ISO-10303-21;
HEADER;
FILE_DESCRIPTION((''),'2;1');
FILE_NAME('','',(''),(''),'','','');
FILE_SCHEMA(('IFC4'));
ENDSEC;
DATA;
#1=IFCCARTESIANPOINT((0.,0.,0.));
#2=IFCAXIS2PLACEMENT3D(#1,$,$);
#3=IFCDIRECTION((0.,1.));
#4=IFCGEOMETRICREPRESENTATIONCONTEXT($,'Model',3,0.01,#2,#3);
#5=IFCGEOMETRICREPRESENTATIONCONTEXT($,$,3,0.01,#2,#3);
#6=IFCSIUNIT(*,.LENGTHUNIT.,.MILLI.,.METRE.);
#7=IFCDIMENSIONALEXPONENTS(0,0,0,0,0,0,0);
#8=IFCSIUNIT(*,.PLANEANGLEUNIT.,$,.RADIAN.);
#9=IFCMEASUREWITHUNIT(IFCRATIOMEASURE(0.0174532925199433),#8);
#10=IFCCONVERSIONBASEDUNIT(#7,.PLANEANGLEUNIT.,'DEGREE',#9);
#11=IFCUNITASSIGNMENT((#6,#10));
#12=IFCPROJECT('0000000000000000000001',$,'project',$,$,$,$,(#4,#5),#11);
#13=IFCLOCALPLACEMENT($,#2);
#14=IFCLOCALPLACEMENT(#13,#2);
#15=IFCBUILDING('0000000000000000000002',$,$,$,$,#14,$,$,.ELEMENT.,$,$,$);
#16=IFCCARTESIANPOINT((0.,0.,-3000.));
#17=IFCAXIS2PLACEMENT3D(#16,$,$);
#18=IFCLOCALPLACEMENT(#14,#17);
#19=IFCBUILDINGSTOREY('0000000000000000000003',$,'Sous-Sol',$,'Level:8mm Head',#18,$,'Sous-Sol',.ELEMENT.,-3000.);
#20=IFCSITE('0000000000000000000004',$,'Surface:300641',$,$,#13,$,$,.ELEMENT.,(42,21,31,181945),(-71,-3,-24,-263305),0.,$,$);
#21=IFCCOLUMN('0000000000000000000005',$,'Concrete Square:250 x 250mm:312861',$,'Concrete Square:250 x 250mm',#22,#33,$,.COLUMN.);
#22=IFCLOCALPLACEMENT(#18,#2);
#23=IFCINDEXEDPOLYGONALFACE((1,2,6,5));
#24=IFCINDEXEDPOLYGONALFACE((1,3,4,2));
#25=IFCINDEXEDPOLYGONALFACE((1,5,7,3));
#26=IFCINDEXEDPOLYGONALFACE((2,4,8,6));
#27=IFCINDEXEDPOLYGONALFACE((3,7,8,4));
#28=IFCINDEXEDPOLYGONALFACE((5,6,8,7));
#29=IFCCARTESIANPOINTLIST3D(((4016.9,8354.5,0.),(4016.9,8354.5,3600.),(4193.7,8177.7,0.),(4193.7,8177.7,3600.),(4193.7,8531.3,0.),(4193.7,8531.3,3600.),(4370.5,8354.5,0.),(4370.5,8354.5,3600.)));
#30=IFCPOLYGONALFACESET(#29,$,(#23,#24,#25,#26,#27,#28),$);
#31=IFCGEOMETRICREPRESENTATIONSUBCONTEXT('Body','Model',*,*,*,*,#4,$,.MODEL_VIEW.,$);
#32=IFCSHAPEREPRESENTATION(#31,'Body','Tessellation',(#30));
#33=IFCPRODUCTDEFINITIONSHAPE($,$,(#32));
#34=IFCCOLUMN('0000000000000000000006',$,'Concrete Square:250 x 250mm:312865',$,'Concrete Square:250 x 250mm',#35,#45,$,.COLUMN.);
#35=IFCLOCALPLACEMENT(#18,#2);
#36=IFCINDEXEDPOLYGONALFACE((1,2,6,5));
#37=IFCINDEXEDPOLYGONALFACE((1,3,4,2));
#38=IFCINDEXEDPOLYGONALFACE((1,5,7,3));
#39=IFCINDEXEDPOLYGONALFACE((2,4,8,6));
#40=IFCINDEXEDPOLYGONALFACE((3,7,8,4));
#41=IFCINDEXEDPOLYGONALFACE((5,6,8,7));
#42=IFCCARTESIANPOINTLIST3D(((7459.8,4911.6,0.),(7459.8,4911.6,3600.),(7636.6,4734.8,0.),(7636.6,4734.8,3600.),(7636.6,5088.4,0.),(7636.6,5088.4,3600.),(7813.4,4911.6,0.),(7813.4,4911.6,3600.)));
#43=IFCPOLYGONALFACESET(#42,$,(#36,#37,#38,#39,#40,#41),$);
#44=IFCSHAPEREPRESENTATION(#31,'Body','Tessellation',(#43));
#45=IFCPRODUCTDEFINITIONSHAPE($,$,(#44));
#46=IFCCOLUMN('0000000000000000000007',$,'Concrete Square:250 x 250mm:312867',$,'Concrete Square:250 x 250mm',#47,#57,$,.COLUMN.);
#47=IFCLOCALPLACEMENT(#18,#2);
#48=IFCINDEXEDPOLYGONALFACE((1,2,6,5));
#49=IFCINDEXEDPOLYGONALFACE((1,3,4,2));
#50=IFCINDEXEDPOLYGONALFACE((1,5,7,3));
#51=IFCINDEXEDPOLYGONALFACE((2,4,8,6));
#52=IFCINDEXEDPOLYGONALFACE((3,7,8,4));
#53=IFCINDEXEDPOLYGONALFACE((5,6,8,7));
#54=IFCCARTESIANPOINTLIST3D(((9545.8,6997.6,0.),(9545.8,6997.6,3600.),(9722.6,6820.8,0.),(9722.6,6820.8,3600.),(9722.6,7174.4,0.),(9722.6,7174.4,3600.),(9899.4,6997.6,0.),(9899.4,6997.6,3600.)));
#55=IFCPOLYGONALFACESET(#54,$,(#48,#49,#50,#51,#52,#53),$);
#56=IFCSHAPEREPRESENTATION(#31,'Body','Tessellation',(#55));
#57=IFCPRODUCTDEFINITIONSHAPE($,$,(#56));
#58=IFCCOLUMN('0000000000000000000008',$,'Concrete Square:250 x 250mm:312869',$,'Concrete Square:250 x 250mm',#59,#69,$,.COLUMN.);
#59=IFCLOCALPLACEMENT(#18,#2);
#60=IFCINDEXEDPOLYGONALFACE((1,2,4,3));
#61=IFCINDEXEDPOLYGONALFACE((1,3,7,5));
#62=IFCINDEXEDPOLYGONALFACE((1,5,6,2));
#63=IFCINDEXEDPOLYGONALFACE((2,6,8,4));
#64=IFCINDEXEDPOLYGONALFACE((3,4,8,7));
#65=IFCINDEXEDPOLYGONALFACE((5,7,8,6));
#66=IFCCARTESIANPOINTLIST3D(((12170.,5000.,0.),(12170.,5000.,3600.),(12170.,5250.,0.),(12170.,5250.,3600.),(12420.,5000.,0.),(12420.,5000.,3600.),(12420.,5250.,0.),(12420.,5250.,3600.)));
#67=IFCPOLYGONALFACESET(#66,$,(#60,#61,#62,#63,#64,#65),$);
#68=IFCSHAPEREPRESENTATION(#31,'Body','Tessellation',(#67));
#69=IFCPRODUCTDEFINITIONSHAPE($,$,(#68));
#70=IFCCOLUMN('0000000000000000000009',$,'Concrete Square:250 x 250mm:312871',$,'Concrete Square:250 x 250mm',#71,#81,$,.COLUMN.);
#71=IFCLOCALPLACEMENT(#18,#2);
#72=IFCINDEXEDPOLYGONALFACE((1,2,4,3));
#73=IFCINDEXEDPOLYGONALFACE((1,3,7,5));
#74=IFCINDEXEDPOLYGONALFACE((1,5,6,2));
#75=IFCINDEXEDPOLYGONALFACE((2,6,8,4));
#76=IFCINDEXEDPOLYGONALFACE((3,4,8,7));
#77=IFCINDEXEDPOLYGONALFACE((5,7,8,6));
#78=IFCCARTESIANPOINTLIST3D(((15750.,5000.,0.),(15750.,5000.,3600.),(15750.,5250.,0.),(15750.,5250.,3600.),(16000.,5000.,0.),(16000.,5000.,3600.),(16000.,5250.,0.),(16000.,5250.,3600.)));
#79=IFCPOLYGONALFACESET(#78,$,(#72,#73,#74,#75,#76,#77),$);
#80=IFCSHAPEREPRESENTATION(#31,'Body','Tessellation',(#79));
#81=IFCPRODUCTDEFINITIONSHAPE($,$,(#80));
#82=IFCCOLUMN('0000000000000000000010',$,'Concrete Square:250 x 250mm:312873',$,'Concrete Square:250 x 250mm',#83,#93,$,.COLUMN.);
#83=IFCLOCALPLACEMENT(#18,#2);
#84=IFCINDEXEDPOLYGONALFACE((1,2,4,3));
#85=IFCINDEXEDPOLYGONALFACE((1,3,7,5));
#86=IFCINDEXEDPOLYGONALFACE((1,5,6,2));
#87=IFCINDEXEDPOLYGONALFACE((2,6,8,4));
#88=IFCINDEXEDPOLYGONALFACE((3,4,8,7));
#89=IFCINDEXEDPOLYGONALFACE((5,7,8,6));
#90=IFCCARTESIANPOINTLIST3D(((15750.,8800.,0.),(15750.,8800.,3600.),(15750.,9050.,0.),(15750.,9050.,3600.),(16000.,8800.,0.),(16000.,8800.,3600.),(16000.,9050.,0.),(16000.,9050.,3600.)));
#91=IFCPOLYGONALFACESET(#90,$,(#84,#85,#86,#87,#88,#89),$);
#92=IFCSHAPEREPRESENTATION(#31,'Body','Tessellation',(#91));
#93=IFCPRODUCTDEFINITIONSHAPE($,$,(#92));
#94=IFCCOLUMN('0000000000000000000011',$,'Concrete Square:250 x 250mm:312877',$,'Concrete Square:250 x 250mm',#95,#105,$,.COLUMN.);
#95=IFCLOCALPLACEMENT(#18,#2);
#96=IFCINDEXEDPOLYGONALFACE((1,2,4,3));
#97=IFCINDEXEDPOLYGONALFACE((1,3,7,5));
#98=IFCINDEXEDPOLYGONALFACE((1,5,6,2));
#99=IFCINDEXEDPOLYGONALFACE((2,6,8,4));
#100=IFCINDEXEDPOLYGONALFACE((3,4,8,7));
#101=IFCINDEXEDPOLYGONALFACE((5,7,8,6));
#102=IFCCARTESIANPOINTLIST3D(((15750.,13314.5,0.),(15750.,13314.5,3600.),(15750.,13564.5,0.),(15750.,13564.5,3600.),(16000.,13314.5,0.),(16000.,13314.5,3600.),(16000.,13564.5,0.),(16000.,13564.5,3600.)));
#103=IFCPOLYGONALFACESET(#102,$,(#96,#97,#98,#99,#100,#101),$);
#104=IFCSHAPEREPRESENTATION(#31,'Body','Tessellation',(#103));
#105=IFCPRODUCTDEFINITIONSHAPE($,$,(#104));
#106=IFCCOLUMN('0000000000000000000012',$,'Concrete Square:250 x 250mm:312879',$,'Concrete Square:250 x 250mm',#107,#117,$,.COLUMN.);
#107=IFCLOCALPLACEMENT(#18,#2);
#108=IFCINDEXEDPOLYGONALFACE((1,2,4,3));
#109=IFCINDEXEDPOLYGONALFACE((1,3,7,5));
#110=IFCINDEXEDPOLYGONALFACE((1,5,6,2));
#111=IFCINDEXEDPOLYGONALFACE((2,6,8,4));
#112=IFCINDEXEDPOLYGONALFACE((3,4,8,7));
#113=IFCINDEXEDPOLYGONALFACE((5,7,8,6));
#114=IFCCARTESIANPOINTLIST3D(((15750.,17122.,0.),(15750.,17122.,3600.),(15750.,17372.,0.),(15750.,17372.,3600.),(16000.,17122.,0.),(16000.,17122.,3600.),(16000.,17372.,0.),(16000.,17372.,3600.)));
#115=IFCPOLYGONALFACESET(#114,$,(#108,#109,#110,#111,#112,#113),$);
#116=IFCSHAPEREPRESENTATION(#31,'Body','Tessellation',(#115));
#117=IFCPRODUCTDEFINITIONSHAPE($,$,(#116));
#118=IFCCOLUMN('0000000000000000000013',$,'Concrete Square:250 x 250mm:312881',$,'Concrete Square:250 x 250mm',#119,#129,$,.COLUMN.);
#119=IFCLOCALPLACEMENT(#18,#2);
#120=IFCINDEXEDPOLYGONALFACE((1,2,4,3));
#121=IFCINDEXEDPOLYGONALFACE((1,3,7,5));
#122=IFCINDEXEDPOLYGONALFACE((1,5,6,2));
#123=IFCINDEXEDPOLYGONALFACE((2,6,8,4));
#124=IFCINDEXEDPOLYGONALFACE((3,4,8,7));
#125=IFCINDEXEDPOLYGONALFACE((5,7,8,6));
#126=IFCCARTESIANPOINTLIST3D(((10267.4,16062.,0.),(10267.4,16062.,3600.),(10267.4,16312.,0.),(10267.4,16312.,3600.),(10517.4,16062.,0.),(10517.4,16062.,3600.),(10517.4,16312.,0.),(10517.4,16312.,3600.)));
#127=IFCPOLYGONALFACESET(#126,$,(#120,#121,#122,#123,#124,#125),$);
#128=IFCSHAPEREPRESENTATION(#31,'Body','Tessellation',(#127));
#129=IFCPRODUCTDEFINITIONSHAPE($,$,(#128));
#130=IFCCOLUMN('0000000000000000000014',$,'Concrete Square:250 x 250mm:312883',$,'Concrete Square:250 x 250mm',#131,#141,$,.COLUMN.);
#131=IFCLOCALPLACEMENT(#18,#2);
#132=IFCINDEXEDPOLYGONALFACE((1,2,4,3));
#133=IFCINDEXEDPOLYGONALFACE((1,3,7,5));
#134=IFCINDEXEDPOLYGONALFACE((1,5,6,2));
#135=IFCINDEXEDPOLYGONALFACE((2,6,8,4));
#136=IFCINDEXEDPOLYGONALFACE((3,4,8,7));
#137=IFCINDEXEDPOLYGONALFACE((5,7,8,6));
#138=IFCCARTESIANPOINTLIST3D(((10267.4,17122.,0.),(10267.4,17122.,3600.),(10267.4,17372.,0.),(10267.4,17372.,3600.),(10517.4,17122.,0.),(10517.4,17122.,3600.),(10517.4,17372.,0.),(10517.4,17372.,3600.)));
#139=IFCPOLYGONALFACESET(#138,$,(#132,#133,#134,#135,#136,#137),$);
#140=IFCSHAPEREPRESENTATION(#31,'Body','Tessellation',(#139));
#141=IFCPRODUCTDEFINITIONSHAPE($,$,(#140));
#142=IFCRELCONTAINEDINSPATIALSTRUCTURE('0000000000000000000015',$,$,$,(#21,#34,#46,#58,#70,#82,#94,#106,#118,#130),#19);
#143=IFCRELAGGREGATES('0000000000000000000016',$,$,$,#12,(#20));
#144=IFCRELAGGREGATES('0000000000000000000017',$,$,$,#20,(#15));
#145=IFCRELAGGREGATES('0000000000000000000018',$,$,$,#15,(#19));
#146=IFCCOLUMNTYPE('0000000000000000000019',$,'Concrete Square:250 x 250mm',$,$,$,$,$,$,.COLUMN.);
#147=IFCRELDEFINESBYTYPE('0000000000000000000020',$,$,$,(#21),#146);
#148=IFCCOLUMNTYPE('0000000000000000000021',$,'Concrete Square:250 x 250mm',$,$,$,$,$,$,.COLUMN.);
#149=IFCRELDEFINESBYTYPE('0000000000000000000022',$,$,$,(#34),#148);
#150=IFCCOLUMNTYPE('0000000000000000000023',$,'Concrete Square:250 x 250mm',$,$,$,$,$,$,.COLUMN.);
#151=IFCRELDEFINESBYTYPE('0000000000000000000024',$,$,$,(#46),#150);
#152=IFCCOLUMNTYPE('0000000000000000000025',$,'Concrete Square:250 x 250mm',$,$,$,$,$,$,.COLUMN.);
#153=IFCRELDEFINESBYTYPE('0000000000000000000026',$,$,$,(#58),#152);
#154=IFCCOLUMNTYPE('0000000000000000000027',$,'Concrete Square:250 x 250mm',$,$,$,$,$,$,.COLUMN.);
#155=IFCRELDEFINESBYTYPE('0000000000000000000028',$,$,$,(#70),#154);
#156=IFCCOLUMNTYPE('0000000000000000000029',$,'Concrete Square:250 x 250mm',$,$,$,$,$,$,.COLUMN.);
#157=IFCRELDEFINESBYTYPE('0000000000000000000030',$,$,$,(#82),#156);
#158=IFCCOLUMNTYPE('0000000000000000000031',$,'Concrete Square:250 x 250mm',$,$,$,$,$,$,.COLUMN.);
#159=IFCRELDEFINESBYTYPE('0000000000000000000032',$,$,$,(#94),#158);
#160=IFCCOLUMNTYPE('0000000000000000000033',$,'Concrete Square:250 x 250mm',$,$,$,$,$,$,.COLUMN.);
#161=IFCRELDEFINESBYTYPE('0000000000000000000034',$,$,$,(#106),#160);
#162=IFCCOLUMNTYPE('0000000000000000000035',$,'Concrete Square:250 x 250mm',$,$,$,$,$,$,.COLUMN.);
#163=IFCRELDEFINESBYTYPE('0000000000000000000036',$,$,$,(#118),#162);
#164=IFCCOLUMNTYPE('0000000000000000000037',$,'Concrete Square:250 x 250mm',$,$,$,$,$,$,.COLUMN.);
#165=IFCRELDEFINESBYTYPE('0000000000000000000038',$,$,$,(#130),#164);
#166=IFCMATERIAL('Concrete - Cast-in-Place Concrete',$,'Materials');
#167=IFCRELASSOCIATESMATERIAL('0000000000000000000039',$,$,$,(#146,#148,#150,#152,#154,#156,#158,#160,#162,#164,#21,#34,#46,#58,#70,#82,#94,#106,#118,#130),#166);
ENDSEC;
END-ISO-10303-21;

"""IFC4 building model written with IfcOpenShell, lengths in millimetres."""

from ifc_helpers import new_model, entity, si_unit, converted_unit, direction, frame, frame_2d, origin, origin_2d_with_axis, place, context, subcontext, project, spatial, rectangle, extrude, source, transform, mapped, material, material_profile, profile_set, profile_usage, type_object, type_shapes, element, save


model = new_model("IFC4")

# Units and contexts
model_context = context("Model", 3, precision=0.01, world=origin(), true_north=direction((0.0, 1.0)))
context_of_model = context(None, 3, precision=0.01, world=origin(), true_north=direction((0.0, 1.0)))
body_context = subcontext(model_context, "Body", "Model", "MODEL_VIEW")
ifc_project = project(units=[si_unit("LENGTHUNIT", "METRE", prefix="MILLI"), converted_unit("PLANEANGLEUNIT", "DEGREE", entity("IfcRatioMeasure", 0.0174532925199433), si_unit("PLANEANGLEUNIT", "RADIAN"), dimensions=[0, 0, 0, 0, 0, 0, 0])], contexts=[model_context, context_of_model])

# Site, building, storey
site_placement = place(None, origin())
site = spatial("IfcSite", under=ifc_project, at=site_placement, Name="Surface:300641", CompositionType="ELEMENT", RefLatitude=(42, 21, 31, 181945), RefLongitude=(-71, -3, -24, -263305), RefElevation=0.0)
building_placement = place(site_placement, origin())
building = spatial("IfcBuilding", under=site, at=building_placement, CompositionType="ELEMENT")
storey_placement = place(building_placement, frame((0.0, 0.0, -3000.0)))
storey = spatial("IfcBuildingStorey", under=building, at=storey_placement, Name="Sous-Sol", ObjectType="Level:8mm Head", LongName="Sous-Sol", CompositionType="ELEMENT", Elevation=-3000.0)

# Columns
ifc_material_1 = material(Name="Concrete - Cast-in-Place Concrete", Category="Materials")
ifc_material_profile = material_profile(ifc_material_1, rectangle(XDim=250.0, YDim=250.0, at=frame_2d((0.0, 0.0), x_axis=(1.0, 0.0))), Name="250 x 250mm")
ifc_profile_set = profile_set([ifc_material_profile], Name="250 x 250mm")
ifc_profile_usage_1 = profile_usage(ifc_profile_set)
column_type_1 = type_object("IfcColumnType", Name="Concrete Square:250 x 250mm", PredefinedType="COLUMN", material=ifc_profile_set)
shared_shape_1 = source(origin(), body_context, "Body", "SweptSolid", [
    extrude(rectangle(XDim=250.0, YDim=250.0, at=frame_2d((0.0, 0.0), x_axis=(1.0, 0.0))), frame((4193.7, 8354.5, -3000.0), z_axis=(0.0, 0.0, 1.0), x_axis=(-0.707107, 0.707107, 0.0)), (0.0, 0.0, 1.0), 3600.0),
])
type_shapes(column_type_1, [shared_shape_1])
column_1_placement = place(storey_placement, frame((0.0, 0.0, 3000.0)))
element("IfcColumn", 1, at=column_1_placement, inside=storey, type_object=column_type_1, material=ifc_profile_usage_1, Name="Concrete Square:250 x 250mm:312861", ObjectType="Concrete Square:250 x 250mm", PredefinedType="COLUMN", context=body_context, shape_type="MappedRepresentation", body=[
    mapped(shared_shape_1, transform((0.0, 0.0, 0.0), scale=1.0)),
])
ifc_profile_usage_2 = profile_usage(ifc_profile_set)
column_type_2 = type_object("IfcColumnType", Name="Concrete Square:250 x 250mm", PredefinedType="COLUMN", material=ifc_profile_set)
shared_shape_2 = source(origin(), body_context, "Body", "SweptSolid", [
    extrude(rectangle(XDim=250.0, YDim=250.0, at=frame_2d((0.0, 0.0), x_axis=(1.0, 0.0))), frame((7636.6, 4911.6, -3000.0), z_axis=(0.0, 0.0, 1.0), x_axis=(-0.707107, 0.707107, 0.0)), (0.0, 0.0, 1.0), 3600.0),
])
type_shapes(column_type_2, [shared_shape_2])
column_2_placement = place(storey_placement, frame((0.0, 0.0, 3000.0)))
element("IfcColumn", 2, at=column_2_placement, inside=storey, type_object=column_type_2, material=ifc_profile_usage_2, Name="Concrete Square:250 x 250mm:312865", ObjectType="Concrete Square:250 x 250mm", PredefinedType="COLUMN", context=body_context, shape_type="MappedRepresentation", body=[
    mapped(shared_shape_2, transform((0.0, 0.0, 0.0), scale=1.0)),
])
ifc_profile_usage_3 = profile_usage(ifc_profile_set)
column_type_3 = type_object("IfcColumnType", Name="Concrete Square:250 x 250mm", PredefinedType="COLUMN", material=ifc_profile_set)
shared_shape_3 = source(origin(), body_context, "Body", "SweptSolid", [
    extrude(rectangle(XDim=250.0, YDim=250.0, at=origin_2d_with_axis()), frame((9722.6, 6997.6, -3000.0), z_axis=(0.0, 0.0, 1.0), x_axis=(-0.707107, 0.707107, 0.0)), (0.0, 0.0, 1.0), 3600.0),
])
type_shapes(column_type_3, [shared_shape_3])
column_3_placement = place(storey_placement, frame((0.0, 0.0, 3000.0)))
element("IfcColumn", 3, at=column_3_placement, inside=storey, type_object=column_type_3, material=ifc_profile_usage_3, Name="Concrete Square:250 x 250mm:312867", ObjectType="Concrete Square:250 x 250mm", PredefinedType="COLUMN", context=body_context, shape_type="MappedRepresentation", body=[
    mapped(shared_shape_3, transform((0.0, 0.0, 0.0), scale=1.0)),
])
ifc_profile_usage_4 = profile_usage(ifc_profile_set)
column_type_4 = type_object("IfcColumnType", Name="Concrete Square:250 x 250mm", PredefinedType="COLUMN", material=ifc_profile_set)
shared_shape_4 = source(origin(), body_context, "Body", "SweptSolid", [
    extrude(rectangle(XDim=250.0, YDim=250.0, at=origin_2d_with_axis()), frame((12295.0, 5125.0, -3000.0), z_axis=(0.0, 0.0, 1.0), x_axis=(0.0, -1.0, 0.0)), (0.0, 0.0, 1.0), 3600.0),
])
type_shapes(column_type_4, [shared_shape_4])
column_4_placement = place(storey_placement, frame((0.0, 0.0, 3000.0)))
element("IfcColumn", 4, at=column_4_placement, inside=storey, type_object=column_type_4, material=ifc_profile_usage_4, Name="Concrete Square:250 x 250mm:312869", ObjectType="Concrete Square:250 x 250mm", PredefinedType="COLUMN", context=body_context, shape_type="MappedRepresentation", body=[
    mapped(shared_shape_4, transform((0.0, 0.0, 0.0), scale=1.0)),
])
ifc_profile_usage_5 = profile_usage(ifc_profile_set)
column_type_5 = type_object("IfcColumnType", Name="Concrete Square:250 x 250mm", PredefinedType="COLUMN", material=ifc_profile_set)
shared_shape_5 = source(origin(), body_context, "Body", "SweptSolid", [
    extrude(rectangle(XDim=250.0, YDim=250.0, at=origin_2d_with_axis()), frame((15875.0, 5125.0, -3000.0), z_axis=(0.0, 0.0, 1.0), x_axis=(0.0, -1.0, 0.0)), (0.0, 0.0, 1.0), 3600.0),
])
type_shapes(column_type_5, [shared_shape_5])
column_5_placement = place(storey_placement, frame((0.0, 0.0, 3000.0)))
element("IfcColumn", 5, at=column_5_placement, inside=storey, type_object=column_type_5, material=ifc_profile_usage_5, Name="Concrete Square:250 x 250mm:312871", ObjectType="Concrete Square:250 x 250mm", PredefinedType="COLUMN", context=body_context, shape_type="MappedRepresentation", body=[
    mapped(shared_shape_5, transform((0.0, 0.0, 0.0), scale=1.0)),
])
ifc_profile_usage_6 = profile_usage(ifc_profile_set)
column_type_6 = type_object("IfcColumnType", Name="Concrete Square:250 x 250mm", PredefinedType="COLUMN", material=ifc_profile_set)
shared_shape_6 = source(origin(), body_context, "Body", "SweptSolid", [
    extrude(rectangle(XDim=250.0, YDim=250.0, at=origin_2d_with_axis()), frame((15875.0, 8925.0, -3000.0), z_axis=(0.0, 0.0, 1.0), x_axis=(0.0, -1.0, 0.0)), (0.0, 0.0, 1.0), 3600.0),
])
type_shapes(column_type_6, [shared_shape_6])
column_6_placement = place(storey_placement, frame((0.0, 0.0, 3000.0)))
element("IfcColumn", 6, at=column_6_placement, inside=storey, type_object=column_type_6, material=ifc_profile_usage_6, Name="Concrete Square:250 x 250mm:312873", ObjectType="Concrete Square:250 x 250mm", PredefinedType="COLUMN", context=body_context, shape_type="MappedRepresentation", body=[
    mapped(shared_shape_6, transform((0.0, 0.0, 0.0), scale=1.0)),
])
ifc_profile_usage_7 = profile_usage(ifc_profile_set)
column_type_7 = type_object("IfcColumnType", Name="Concrete Square:250 x 250mm", PredefinedType="COLUMN", material=ifc_profile_set)
shared_shape_7 = source(origin(), body_context, "Body", "SweptSolid", [
    extrude(rectangle(XDim=250.0, YDim=250.0, at=frame_2d((0.0, 0.0), x_axis=(1.0, 0.0))), frame((15875.0, 13439.5, -3000.0), z_axis=(0.0, 0.0, 1.0), x_axis=(0.0, -1.0, 0.0)), (0.0, 0.0, 1.0), 3600.0),
])
type_shapes(column_type_7, [shared_shape_7])
column_7_placement = place(storey_placement, frame((0.0, 0.0, 3000.0)))
element("IfcColumn", 7, at=column_7_placement, inside=storey, type_object=column_type_7, material=ifc_profile_usage_7, Name="Concrete Square:250 x 250mm:312877", ObjectType="Concrete Square:250 x 250mm", PredefinedType="COLUMN", context=body_context, shape_type="MappedRepresentation", body=[
    mapped(shared_shape_7, transform((0.0, 0.0, 0.0), scale=1.0)),
])
ifc_profile_usage_8 = profile_usage(ifc_profile_set)
column_type_8 = type_object("IfcColumnType", Name="Concrete Square:250 x 250mm", PredefinedType="COLUMN", material=ifc_profile_set)
shared_shape_8 = source(origin(), body_context, "Body", "SweptSolid", [
    extrude(rectangle(XDim=250.0, YDim=250.0, at=origin_2d_with_axis()), frame((15875.0, 17247.0, -3000.0), z_axis=(0.0, 0.0, 1.0), x_axis=(0.0, -1.0, 0.0)), (0.0, 0.0, 1.0), 3600.0),
])
type_shapes(column_type_8, [shared_shape_8])
column_8_placement = place(storey_placement, frame((0.0, 0.0, 3000.0)))
element("IfcColumn", 8, at=column_8_placement, inside=storey, type_object=column_type_8, material=ifc_profile_usage_8, Name="Concrete Square:250 x 250mm:312879", ObjectType="Concrete Square:250 x 250mm", PredefinedType="COLUMN", context=body_context, shape_type="MappedRepresentation", body=[
    mapped(shared_shape_8, transform((0.0, 0.0, 0.0), scale=1.0)),
])
ifc_profile_usage_9 = profile_usage(ifc_profile_set)
column_type_9 = type_object("IfcColumnType", Name="Concrete Square:250 x 250mm", PredefinedType="COLUMN", material=ifc_profile_set)
shared_shape_9 = source(origin(), body_context, "Body", "SweptSolid", [
    extrude(rectangle(XDim=250.0, YDim=250.0, at=frame_2d((0.0, 0.0), x_axis=(1.0, 0.0))), frame((10392.4, 16187.0, -3000.0), z_axis=(0.0, 0.0, 1.0), x_axis=(0.0, -1.0, 0.0)), (0.0, 0.0, 1.0), 3600.0),
])
type_shapes(column_type_9, [shared_shape_9])
column_9_placement = place(storey_placement, frame((0.0, 0.0, 3000.0)))
element("IfcColumn", 9, at=column_9_placement, inside=storey, type_object=column_type_9, material=ifc_profile_usage_9, Name="Concrete Square:250 x 250mm:312881", ObjectType="Concrete Square:250 x 250mm", PredefinedType="COLUMN", context=body_context, shape_type="MappedRepresentation", body=[
    mapped(shared_shape_9, transform((0.0, 0.0, 0.0), scale=1.0)),
])
ifc_profile_usage_10 = profile_usage(ifc_profile_set)
column_type_10 = type_object("IfcColumnType", Name="Concrete Square:250 x 250mm", PredefinedType="COLUMN", material=ifc_profile_set)
shared_shape_10 = source(origin(), body_context, "Body", "SweptSolid", [
    extrude(rectangle(XDim=250.0, YDim=250.0, at=origin_2d_with_axis()), frame((10392.4, 17247.0, -3000.0), z_axis=(0.0, 0.0, 1.0), x_axis=(0.0, -1.0, 0.0)), (0.0, 0.0, 1.0), 3600.0),
])
type_shapes(column_type_10, [shared_shape_10])
column_10_placement = place(storey_placement, frame((0.0, 0.0, 3000.0)))
element("IfcColumn", 10, at=column_10_placement, inside=storey, type_object=column_type_10, material=ifc_profile_usage_10, Name="Concrete Square:250 x 250mm:312883", ObjectType="Concrete Square:250 x 250mm", PredefinedType="COLUMN", context=body_context, shape_type="MappedRepresentation", body=[
    mapped(shared_shape_10, transform((0.0, 0.0, 0.0), scale=1.0)),
])

save(model, "model.ifc")
